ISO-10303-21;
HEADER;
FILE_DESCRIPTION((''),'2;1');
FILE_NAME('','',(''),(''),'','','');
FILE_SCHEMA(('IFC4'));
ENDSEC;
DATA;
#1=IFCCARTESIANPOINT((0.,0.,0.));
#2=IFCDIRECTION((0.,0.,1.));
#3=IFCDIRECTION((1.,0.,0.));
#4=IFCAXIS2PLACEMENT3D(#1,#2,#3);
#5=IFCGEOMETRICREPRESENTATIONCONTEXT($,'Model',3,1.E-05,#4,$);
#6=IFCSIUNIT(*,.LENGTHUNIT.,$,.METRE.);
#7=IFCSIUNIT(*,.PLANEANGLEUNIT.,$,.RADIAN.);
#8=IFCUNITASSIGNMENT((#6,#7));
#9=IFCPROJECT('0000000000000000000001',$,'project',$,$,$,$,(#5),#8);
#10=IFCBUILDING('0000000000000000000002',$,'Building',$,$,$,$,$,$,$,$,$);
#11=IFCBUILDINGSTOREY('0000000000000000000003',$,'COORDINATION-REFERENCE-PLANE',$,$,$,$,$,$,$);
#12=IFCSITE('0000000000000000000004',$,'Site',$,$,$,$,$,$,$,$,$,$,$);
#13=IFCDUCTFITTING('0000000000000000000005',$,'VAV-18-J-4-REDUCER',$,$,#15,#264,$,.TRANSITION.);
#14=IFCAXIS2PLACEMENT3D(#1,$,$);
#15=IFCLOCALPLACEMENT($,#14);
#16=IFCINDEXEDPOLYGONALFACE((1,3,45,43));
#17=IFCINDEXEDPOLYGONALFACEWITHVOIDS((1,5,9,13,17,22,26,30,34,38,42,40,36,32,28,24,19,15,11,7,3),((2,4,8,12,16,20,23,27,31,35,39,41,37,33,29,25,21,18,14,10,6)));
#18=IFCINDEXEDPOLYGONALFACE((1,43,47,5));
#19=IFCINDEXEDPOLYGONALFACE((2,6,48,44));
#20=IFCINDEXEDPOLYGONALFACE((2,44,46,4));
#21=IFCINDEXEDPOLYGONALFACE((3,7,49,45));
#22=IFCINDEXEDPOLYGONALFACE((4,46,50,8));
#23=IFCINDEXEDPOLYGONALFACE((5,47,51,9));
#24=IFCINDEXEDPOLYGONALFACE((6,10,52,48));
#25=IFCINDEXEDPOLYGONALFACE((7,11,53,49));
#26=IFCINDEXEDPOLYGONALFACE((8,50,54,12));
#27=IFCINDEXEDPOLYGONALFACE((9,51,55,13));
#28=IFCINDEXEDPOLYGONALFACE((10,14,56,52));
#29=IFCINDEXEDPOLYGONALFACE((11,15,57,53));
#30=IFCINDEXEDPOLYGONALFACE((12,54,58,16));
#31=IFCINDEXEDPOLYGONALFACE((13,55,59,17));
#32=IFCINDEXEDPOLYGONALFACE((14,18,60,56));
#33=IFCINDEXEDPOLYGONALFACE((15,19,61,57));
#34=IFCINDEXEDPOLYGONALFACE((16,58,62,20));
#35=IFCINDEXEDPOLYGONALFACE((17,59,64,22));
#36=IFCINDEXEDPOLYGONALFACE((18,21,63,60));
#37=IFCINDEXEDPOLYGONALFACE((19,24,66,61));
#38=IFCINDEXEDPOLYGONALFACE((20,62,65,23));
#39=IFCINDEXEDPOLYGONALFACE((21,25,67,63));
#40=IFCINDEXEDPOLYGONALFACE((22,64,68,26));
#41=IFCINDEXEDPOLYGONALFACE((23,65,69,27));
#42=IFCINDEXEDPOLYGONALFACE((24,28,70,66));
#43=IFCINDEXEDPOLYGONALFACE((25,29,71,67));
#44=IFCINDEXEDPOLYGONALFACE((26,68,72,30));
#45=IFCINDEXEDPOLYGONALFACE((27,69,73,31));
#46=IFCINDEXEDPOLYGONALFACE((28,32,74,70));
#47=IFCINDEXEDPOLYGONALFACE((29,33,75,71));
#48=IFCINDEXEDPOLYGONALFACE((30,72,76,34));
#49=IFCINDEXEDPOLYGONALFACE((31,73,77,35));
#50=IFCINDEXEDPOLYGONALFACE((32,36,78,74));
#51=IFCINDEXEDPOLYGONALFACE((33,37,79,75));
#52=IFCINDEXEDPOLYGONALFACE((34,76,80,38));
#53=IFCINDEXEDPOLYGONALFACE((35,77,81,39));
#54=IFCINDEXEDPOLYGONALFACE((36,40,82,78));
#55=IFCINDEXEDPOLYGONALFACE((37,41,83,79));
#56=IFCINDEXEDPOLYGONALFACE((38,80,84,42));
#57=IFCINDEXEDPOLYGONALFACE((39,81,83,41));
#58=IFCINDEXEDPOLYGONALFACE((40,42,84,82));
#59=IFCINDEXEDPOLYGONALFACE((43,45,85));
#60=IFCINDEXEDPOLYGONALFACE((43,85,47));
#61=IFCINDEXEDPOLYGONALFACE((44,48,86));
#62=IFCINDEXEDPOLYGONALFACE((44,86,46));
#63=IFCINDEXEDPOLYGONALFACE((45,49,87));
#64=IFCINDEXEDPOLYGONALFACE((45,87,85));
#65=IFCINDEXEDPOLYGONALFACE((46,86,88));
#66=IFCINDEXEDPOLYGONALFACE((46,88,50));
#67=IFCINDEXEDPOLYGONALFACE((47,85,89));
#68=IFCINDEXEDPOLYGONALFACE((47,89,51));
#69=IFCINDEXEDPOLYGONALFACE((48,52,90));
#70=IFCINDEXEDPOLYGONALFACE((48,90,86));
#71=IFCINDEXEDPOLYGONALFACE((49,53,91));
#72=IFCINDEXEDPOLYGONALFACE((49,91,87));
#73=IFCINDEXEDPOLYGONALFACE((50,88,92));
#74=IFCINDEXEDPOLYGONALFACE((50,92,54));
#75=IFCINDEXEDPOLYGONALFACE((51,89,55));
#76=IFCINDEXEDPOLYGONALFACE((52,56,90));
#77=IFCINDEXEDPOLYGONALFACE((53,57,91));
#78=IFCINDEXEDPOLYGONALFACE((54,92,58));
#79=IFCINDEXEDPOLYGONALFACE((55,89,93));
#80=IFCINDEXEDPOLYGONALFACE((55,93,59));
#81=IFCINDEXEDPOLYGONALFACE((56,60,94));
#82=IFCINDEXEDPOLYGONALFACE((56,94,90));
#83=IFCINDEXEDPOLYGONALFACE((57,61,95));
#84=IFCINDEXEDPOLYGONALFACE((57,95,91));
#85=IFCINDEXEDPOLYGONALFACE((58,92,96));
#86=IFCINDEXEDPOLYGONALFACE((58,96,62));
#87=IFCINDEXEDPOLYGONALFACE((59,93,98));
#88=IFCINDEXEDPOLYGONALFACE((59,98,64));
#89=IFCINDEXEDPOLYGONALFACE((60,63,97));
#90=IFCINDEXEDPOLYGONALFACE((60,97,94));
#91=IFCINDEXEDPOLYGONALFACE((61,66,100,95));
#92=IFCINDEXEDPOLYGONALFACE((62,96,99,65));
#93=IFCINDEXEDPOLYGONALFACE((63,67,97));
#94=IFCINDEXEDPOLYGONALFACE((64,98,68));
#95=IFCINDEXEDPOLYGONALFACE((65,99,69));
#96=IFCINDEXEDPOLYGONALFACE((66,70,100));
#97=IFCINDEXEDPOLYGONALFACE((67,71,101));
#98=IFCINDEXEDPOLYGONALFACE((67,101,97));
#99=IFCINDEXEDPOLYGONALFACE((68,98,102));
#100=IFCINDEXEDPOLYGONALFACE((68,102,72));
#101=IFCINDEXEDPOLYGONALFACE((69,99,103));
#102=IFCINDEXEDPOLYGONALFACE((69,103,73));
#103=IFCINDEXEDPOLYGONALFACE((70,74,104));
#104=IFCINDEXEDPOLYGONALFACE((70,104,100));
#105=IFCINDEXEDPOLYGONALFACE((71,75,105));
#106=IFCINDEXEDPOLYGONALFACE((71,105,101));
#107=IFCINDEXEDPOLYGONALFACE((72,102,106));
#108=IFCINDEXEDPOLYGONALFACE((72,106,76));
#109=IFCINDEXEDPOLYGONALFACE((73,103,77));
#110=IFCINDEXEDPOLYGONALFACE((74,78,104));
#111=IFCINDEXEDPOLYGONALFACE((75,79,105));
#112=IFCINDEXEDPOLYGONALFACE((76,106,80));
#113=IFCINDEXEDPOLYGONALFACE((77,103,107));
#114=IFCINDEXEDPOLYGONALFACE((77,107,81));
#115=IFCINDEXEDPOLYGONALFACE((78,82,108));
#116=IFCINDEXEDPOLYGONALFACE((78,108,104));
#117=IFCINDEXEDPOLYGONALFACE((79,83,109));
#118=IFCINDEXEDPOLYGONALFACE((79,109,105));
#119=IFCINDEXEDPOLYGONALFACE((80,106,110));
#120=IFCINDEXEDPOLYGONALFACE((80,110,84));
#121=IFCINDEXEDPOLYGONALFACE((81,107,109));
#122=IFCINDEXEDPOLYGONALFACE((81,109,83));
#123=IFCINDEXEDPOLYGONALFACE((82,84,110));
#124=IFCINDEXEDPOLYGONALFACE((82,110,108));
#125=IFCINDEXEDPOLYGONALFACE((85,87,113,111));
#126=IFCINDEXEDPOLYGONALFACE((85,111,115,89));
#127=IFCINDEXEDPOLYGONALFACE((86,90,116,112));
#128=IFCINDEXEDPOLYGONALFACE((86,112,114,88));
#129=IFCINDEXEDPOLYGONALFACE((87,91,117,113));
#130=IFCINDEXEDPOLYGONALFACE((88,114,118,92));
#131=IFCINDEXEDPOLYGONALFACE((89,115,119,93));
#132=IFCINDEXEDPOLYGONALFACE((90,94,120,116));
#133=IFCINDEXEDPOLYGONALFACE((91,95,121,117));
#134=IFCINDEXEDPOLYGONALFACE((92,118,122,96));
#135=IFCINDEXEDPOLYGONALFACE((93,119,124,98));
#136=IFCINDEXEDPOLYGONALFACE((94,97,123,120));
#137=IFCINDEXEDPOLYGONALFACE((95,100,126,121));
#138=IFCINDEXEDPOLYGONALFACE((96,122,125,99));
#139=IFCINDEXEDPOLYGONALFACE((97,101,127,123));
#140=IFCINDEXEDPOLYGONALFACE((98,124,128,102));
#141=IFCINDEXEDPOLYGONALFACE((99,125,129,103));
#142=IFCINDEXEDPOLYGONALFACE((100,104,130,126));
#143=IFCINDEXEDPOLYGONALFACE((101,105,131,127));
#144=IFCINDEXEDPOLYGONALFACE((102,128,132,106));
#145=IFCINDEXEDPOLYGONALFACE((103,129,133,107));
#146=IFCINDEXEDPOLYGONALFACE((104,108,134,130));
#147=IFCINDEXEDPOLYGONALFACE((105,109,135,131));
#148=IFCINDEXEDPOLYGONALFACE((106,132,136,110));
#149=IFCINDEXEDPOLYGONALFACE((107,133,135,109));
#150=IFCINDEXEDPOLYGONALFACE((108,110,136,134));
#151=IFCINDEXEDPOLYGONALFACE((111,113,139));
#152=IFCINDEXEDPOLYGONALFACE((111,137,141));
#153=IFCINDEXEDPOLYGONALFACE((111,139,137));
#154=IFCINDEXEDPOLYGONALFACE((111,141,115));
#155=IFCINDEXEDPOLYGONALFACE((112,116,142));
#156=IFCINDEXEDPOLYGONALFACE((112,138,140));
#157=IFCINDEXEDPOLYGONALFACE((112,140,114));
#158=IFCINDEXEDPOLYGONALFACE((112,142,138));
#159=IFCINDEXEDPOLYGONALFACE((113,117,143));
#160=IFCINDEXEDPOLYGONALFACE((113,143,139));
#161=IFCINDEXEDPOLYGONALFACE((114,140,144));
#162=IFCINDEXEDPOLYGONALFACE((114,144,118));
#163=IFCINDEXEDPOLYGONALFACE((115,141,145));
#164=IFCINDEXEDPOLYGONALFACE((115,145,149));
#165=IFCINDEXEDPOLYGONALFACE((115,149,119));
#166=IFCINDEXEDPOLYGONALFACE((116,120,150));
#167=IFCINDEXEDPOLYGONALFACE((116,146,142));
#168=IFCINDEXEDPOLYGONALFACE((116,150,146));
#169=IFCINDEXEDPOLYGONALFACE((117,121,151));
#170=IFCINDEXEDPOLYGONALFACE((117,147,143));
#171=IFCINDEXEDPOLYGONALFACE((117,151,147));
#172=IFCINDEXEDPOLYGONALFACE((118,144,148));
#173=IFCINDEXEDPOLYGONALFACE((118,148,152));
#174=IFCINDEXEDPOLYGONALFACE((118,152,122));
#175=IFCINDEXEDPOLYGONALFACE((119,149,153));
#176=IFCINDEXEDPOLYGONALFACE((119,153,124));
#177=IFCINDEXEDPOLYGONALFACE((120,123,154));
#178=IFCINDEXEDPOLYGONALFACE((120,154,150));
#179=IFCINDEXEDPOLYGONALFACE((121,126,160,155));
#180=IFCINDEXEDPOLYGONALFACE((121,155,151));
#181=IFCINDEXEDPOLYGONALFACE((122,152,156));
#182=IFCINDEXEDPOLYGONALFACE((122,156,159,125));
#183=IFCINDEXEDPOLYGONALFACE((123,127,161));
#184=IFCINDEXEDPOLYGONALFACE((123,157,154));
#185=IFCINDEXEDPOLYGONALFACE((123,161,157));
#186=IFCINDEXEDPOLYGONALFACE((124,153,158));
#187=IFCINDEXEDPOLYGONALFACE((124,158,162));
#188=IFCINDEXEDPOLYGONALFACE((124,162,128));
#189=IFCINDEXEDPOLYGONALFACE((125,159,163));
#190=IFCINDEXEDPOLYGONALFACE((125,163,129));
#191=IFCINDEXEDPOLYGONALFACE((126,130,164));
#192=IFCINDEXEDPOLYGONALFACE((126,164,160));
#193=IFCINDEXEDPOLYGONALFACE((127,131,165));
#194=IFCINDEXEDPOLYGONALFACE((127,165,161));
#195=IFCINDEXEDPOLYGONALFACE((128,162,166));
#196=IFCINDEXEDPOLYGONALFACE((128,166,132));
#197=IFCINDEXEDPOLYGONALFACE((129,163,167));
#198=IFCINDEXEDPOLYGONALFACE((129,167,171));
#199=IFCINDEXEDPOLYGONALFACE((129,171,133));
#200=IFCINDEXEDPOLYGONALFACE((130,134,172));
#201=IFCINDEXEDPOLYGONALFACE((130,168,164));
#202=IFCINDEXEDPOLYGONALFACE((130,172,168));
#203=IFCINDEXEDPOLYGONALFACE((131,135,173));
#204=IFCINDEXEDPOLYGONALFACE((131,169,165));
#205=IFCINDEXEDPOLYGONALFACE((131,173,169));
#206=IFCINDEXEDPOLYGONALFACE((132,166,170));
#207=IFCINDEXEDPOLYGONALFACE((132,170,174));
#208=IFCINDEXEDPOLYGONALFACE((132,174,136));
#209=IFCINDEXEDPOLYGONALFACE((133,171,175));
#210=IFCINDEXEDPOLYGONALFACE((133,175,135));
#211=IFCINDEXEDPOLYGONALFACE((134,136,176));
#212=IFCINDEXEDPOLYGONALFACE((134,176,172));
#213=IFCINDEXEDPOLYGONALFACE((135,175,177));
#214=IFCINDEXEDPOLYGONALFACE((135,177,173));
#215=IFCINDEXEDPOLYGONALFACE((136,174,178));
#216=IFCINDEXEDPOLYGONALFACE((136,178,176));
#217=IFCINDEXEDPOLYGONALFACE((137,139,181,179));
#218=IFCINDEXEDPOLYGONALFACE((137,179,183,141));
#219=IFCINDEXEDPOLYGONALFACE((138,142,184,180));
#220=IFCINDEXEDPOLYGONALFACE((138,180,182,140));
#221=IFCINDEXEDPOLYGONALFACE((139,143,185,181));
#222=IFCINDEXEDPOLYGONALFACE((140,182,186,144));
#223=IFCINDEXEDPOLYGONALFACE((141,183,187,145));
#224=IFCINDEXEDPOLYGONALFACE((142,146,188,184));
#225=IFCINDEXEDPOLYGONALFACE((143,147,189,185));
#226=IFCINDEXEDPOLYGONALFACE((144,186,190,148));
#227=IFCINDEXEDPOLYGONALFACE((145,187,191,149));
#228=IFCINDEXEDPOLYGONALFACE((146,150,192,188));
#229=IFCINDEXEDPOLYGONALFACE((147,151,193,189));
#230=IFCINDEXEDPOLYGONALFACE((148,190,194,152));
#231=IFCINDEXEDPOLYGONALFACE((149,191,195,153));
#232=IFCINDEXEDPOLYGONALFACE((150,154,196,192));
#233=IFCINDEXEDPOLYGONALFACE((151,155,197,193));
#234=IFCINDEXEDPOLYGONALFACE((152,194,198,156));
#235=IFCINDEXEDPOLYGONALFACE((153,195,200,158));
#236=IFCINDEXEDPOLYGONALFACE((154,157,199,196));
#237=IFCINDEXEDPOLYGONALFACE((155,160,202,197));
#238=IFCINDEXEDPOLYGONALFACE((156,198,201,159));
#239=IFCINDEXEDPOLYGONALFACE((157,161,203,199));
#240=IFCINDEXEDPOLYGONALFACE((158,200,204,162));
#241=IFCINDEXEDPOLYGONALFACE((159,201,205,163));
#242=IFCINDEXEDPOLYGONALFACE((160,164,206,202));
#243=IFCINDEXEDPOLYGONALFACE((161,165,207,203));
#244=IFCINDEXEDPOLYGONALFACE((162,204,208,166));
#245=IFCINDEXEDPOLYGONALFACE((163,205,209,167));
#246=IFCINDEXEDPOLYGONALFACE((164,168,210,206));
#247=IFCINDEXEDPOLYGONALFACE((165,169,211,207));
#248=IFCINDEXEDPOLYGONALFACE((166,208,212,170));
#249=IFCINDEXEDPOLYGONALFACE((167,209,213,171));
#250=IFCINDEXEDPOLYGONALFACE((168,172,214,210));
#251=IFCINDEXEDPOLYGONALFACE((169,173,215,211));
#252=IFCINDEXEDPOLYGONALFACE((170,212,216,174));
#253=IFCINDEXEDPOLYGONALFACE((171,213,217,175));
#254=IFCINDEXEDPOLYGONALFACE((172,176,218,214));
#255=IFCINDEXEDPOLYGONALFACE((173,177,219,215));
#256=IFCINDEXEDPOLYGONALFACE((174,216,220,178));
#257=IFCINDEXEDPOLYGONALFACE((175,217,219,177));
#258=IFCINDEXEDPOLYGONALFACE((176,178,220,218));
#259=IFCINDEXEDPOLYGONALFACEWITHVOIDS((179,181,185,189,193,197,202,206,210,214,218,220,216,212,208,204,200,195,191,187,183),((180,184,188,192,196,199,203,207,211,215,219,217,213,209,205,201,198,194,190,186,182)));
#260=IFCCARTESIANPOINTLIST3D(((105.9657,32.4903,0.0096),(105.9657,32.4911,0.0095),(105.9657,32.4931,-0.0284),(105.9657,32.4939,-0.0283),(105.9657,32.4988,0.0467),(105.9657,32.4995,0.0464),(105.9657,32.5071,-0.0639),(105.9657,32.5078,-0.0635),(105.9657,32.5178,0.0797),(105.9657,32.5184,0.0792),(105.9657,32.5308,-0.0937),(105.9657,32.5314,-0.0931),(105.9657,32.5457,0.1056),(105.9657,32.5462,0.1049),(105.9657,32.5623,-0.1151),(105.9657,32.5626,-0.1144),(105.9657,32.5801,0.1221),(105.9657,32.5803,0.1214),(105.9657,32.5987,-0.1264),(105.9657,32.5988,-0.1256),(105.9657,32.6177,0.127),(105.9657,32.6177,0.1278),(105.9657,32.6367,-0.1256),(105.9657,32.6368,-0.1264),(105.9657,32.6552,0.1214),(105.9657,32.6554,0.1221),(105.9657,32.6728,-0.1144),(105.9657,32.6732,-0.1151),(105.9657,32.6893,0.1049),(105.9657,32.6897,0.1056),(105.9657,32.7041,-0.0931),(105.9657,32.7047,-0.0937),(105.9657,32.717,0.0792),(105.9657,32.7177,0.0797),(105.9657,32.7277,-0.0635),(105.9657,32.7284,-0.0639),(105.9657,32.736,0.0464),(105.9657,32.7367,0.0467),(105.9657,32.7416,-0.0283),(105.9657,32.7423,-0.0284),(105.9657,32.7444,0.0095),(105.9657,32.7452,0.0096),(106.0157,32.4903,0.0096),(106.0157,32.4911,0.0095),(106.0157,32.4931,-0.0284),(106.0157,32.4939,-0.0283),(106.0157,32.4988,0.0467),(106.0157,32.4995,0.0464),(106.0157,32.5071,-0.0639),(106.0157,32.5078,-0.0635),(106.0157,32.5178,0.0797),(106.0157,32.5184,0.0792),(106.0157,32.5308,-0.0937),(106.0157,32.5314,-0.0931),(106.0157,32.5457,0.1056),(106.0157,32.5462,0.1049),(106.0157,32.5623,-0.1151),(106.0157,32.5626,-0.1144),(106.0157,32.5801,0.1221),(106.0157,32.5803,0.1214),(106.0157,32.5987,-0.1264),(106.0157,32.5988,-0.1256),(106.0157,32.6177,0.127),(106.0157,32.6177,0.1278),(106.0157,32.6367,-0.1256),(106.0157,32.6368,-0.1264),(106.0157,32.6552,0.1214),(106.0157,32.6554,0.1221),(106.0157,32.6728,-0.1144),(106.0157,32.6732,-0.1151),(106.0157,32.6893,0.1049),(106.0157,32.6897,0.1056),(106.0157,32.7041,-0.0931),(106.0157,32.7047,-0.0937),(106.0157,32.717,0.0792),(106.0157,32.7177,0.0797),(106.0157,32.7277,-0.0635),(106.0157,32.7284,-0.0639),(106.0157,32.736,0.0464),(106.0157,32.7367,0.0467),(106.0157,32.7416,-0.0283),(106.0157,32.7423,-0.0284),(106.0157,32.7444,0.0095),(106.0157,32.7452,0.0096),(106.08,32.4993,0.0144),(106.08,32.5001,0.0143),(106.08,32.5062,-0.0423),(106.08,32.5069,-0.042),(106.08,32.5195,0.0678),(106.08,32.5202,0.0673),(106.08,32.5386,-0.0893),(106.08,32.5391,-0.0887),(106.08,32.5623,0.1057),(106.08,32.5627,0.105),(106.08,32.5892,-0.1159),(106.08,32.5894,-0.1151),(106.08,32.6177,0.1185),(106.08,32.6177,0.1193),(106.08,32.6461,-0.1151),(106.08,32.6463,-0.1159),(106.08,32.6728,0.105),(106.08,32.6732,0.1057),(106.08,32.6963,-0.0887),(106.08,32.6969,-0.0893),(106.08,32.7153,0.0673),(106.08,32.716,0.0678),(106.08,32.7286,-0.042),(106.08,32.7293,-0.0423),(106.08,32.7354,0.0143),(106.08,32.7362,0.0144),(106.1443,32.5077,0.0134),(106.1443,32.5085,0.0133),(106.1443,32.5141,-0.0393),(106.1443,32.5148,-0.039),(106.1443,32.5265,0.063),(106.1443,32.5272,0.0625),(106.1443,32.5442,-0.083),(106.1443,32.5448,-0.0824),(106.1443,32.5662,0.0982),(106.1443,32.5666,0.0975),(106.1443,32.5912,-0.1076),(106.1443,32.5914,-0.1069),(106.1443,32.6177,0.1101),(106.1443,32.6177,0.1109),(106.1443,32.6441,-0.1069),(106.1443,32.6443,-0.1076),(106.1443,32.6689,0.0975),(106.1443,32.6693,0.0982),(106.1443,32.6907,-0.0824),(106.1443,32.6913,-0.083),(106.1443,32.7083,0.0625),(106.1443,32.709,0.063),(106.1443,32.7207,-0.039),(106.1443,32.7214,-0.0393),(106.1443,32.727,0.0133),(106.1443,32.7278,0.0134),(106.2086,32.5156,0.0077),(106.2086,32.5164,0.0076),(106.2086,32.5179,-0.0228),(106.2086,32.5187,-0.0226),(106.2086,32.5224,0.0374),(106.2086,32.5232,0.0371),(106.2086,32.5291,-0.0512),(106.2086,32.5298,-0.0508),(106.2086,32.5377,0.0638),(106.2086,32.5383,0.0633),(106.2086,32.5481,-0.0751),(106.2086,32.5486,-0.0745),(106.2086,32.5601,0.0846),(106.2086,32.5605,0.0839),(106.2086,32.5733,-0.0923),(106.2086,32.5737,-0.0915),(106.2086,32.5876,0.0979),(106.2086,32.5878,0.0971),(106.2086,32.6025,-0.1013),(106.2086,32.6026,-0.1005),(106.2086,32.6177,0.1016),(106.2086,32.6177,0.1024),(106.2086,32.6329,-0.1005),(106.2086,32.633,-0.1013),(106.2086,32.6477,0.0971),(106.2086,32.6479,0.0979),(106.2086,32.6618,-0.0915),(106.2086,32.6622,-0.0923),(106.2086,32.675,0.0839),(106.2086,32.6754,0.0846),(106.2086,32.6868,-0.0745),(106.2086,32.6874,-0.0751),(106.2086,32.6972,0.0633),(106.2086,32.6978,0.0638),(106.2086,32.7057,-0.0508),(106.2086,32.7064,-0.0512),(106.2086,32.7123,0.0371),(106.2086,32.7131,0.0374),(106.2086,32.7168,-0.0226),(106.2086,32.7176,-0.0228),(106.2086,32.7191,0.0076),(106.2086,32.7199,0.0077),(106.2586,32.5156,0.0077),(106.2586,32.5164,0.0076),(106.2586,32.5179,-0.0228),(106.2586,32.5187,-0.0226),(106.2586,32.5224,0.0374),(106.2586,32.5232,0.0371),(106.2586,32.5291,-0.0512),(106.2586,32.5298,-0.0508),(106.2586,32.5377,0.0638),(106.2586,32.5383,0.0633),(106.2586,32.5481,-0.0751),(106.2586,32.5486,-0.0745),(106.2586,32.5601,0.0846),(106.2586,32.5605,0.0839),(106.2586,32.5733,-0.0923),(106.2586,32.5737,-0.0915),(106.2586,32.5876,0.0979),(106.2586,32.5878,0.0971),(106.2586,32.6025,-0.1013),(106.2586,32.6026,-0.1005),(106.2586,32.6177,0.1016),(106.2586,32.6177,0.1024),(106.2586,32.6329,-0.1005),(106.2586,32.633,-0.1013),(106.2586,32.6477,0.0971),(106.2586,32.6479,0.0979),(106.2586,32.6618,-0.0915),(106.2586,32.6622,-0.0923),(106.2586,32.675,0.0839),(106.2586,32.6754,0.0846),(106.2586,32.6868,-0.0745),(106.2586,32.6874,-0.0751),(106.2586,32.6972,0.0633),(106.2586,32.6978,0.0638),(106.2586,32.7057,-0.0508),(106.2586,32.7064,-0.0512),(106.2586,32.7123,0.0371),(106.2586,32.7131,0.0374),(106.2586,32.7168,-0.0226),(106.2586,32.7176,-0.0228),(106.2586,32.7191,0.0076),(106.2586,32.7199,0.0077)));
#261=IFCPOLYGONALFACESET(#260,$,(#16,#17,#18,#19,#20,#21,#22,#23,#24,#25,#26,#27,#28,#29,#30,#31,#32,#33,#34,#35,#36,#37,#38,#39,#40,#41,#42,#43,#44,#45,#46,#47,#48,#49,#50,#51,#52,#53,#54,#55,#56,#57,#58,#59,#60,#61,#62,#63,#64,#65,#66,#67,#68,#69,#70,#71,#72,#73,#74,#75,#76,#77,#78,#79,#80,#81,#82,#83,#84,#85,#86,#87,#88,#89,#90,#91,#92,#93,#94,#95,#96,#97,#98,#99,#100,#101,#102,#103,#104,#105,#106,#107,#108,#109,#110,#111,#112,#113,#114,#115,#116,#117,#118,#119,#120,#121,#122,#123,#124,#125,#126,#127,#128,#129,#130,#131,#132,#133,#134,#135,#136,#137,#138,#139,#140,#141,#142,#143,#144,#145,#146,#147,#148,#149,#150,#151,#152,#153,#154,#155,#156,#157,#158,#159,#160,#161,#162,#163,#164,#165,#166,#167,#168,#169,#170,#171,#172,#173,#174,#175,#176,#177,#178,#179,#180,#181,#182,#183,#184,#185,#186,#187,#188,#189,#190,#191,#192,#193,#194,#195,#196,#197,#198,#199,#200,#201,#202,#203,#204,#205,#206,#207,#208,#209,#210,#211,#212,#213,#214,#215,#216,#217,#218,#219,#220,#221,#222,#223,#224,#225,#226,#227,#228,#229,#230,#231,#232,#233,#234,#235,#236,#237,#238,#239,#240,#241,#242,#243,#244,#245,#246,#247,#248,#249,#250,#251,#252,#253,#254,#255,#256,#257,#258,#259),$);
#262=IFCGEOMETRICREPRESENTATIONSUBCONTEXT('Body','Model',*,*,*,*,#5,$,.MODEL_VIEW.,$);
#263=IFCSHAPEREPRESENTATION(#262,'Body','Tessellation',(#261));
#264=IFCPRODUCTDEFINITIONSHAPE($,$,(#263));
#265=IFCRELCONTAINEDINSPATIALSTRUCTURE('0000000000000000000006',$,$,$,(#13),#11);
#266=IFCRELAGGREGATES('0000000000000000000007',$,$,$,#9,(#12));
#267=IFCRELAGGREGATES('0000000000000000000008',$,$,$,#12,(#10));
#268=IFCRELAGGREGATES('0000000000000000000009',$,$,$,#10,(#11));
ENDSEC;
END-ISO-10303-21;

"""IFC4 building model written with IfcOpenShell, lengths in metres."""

from ifc_helpers import new_model, entity, si_unit, frame, origin_with_axes, place, context, subcontext, project, spatial, element, save


model = new_model("IFC4")

# Units and contexts
model_context = context("Model", 3, precision=1e-05, world=origin_with_axes())
body_context_1 = subcontext(model_context, "Body", "Model", "MODEL_VIEW")
ifc_project = project(units=[si_unit("LENGTHUNIT", "METRE"), si_unit("PLANEANGLEUNIT", "RADIAN")], contexts=[model_context])

# Site, building, storey
site = spatial("IfcSite", under=ifc_project, Name="Site")
building = spatial("IfcBuilding", under=site, Name="Building")
storey = spatial("IfcBuildingStorey", under=building, Name="COORDINATION-REFERENCE-PLANE")

# Duct fitting
for number, where, z_axis, x_axis, name in (
    (1, (105.9657, 32.6177, 0.0), (0.0, 1.0, 0.0), (0.0, 0.0, 1.0), "VAV-18-J-4-REDUCER"),
):
    element("IfcDuctFitting", number, at=place(None, frame(where, z_axis=z_axis, x_axis=x_axis)), inside=storey, Name=name, PredefinedType="TRANSITION", context=body_context_1, shape_type="SweptSolid", body=[
        entity("IfcRevolvedAreaSolid", entity("IfcArbitraryClosedProfileDef", "AREA", None, entity("IfcPolyline", [entity("IfcCartesianPoint", [0.1278, 0.0]), entity("IfcCartesianPoint", [0.1278, 0.05]), entity("IfcCartesianPoint", [0.1024, 0.2429]), entity("IfcCartesianPoint", [0.1024, 0.2929]), entity("IfcCartesianPoint", [0.1016, 0.2929]), entity("IfcCartesianPoint", [0.1016, 0.2429]), entity("IfcCartesianPoint", [0.127, 0.05]), entity("IfcCartesianPoint", [0.127, 0.0]), entity("IfcCartesianPoint", [0.1278, 0.0])])), entity("IfcAxis2Placement3D", entity("IfcCartesianPoint", [0.0, 0.0, 0.0])), entity("IfcAxis1Placement", entity("IfcCartesianPoint", [0.0, 0.0, 0.0]), entity("IfcDirection", [0.0, 1.0, 0.0])), 6.283185),
    ])

save(model, "model.ifc")
